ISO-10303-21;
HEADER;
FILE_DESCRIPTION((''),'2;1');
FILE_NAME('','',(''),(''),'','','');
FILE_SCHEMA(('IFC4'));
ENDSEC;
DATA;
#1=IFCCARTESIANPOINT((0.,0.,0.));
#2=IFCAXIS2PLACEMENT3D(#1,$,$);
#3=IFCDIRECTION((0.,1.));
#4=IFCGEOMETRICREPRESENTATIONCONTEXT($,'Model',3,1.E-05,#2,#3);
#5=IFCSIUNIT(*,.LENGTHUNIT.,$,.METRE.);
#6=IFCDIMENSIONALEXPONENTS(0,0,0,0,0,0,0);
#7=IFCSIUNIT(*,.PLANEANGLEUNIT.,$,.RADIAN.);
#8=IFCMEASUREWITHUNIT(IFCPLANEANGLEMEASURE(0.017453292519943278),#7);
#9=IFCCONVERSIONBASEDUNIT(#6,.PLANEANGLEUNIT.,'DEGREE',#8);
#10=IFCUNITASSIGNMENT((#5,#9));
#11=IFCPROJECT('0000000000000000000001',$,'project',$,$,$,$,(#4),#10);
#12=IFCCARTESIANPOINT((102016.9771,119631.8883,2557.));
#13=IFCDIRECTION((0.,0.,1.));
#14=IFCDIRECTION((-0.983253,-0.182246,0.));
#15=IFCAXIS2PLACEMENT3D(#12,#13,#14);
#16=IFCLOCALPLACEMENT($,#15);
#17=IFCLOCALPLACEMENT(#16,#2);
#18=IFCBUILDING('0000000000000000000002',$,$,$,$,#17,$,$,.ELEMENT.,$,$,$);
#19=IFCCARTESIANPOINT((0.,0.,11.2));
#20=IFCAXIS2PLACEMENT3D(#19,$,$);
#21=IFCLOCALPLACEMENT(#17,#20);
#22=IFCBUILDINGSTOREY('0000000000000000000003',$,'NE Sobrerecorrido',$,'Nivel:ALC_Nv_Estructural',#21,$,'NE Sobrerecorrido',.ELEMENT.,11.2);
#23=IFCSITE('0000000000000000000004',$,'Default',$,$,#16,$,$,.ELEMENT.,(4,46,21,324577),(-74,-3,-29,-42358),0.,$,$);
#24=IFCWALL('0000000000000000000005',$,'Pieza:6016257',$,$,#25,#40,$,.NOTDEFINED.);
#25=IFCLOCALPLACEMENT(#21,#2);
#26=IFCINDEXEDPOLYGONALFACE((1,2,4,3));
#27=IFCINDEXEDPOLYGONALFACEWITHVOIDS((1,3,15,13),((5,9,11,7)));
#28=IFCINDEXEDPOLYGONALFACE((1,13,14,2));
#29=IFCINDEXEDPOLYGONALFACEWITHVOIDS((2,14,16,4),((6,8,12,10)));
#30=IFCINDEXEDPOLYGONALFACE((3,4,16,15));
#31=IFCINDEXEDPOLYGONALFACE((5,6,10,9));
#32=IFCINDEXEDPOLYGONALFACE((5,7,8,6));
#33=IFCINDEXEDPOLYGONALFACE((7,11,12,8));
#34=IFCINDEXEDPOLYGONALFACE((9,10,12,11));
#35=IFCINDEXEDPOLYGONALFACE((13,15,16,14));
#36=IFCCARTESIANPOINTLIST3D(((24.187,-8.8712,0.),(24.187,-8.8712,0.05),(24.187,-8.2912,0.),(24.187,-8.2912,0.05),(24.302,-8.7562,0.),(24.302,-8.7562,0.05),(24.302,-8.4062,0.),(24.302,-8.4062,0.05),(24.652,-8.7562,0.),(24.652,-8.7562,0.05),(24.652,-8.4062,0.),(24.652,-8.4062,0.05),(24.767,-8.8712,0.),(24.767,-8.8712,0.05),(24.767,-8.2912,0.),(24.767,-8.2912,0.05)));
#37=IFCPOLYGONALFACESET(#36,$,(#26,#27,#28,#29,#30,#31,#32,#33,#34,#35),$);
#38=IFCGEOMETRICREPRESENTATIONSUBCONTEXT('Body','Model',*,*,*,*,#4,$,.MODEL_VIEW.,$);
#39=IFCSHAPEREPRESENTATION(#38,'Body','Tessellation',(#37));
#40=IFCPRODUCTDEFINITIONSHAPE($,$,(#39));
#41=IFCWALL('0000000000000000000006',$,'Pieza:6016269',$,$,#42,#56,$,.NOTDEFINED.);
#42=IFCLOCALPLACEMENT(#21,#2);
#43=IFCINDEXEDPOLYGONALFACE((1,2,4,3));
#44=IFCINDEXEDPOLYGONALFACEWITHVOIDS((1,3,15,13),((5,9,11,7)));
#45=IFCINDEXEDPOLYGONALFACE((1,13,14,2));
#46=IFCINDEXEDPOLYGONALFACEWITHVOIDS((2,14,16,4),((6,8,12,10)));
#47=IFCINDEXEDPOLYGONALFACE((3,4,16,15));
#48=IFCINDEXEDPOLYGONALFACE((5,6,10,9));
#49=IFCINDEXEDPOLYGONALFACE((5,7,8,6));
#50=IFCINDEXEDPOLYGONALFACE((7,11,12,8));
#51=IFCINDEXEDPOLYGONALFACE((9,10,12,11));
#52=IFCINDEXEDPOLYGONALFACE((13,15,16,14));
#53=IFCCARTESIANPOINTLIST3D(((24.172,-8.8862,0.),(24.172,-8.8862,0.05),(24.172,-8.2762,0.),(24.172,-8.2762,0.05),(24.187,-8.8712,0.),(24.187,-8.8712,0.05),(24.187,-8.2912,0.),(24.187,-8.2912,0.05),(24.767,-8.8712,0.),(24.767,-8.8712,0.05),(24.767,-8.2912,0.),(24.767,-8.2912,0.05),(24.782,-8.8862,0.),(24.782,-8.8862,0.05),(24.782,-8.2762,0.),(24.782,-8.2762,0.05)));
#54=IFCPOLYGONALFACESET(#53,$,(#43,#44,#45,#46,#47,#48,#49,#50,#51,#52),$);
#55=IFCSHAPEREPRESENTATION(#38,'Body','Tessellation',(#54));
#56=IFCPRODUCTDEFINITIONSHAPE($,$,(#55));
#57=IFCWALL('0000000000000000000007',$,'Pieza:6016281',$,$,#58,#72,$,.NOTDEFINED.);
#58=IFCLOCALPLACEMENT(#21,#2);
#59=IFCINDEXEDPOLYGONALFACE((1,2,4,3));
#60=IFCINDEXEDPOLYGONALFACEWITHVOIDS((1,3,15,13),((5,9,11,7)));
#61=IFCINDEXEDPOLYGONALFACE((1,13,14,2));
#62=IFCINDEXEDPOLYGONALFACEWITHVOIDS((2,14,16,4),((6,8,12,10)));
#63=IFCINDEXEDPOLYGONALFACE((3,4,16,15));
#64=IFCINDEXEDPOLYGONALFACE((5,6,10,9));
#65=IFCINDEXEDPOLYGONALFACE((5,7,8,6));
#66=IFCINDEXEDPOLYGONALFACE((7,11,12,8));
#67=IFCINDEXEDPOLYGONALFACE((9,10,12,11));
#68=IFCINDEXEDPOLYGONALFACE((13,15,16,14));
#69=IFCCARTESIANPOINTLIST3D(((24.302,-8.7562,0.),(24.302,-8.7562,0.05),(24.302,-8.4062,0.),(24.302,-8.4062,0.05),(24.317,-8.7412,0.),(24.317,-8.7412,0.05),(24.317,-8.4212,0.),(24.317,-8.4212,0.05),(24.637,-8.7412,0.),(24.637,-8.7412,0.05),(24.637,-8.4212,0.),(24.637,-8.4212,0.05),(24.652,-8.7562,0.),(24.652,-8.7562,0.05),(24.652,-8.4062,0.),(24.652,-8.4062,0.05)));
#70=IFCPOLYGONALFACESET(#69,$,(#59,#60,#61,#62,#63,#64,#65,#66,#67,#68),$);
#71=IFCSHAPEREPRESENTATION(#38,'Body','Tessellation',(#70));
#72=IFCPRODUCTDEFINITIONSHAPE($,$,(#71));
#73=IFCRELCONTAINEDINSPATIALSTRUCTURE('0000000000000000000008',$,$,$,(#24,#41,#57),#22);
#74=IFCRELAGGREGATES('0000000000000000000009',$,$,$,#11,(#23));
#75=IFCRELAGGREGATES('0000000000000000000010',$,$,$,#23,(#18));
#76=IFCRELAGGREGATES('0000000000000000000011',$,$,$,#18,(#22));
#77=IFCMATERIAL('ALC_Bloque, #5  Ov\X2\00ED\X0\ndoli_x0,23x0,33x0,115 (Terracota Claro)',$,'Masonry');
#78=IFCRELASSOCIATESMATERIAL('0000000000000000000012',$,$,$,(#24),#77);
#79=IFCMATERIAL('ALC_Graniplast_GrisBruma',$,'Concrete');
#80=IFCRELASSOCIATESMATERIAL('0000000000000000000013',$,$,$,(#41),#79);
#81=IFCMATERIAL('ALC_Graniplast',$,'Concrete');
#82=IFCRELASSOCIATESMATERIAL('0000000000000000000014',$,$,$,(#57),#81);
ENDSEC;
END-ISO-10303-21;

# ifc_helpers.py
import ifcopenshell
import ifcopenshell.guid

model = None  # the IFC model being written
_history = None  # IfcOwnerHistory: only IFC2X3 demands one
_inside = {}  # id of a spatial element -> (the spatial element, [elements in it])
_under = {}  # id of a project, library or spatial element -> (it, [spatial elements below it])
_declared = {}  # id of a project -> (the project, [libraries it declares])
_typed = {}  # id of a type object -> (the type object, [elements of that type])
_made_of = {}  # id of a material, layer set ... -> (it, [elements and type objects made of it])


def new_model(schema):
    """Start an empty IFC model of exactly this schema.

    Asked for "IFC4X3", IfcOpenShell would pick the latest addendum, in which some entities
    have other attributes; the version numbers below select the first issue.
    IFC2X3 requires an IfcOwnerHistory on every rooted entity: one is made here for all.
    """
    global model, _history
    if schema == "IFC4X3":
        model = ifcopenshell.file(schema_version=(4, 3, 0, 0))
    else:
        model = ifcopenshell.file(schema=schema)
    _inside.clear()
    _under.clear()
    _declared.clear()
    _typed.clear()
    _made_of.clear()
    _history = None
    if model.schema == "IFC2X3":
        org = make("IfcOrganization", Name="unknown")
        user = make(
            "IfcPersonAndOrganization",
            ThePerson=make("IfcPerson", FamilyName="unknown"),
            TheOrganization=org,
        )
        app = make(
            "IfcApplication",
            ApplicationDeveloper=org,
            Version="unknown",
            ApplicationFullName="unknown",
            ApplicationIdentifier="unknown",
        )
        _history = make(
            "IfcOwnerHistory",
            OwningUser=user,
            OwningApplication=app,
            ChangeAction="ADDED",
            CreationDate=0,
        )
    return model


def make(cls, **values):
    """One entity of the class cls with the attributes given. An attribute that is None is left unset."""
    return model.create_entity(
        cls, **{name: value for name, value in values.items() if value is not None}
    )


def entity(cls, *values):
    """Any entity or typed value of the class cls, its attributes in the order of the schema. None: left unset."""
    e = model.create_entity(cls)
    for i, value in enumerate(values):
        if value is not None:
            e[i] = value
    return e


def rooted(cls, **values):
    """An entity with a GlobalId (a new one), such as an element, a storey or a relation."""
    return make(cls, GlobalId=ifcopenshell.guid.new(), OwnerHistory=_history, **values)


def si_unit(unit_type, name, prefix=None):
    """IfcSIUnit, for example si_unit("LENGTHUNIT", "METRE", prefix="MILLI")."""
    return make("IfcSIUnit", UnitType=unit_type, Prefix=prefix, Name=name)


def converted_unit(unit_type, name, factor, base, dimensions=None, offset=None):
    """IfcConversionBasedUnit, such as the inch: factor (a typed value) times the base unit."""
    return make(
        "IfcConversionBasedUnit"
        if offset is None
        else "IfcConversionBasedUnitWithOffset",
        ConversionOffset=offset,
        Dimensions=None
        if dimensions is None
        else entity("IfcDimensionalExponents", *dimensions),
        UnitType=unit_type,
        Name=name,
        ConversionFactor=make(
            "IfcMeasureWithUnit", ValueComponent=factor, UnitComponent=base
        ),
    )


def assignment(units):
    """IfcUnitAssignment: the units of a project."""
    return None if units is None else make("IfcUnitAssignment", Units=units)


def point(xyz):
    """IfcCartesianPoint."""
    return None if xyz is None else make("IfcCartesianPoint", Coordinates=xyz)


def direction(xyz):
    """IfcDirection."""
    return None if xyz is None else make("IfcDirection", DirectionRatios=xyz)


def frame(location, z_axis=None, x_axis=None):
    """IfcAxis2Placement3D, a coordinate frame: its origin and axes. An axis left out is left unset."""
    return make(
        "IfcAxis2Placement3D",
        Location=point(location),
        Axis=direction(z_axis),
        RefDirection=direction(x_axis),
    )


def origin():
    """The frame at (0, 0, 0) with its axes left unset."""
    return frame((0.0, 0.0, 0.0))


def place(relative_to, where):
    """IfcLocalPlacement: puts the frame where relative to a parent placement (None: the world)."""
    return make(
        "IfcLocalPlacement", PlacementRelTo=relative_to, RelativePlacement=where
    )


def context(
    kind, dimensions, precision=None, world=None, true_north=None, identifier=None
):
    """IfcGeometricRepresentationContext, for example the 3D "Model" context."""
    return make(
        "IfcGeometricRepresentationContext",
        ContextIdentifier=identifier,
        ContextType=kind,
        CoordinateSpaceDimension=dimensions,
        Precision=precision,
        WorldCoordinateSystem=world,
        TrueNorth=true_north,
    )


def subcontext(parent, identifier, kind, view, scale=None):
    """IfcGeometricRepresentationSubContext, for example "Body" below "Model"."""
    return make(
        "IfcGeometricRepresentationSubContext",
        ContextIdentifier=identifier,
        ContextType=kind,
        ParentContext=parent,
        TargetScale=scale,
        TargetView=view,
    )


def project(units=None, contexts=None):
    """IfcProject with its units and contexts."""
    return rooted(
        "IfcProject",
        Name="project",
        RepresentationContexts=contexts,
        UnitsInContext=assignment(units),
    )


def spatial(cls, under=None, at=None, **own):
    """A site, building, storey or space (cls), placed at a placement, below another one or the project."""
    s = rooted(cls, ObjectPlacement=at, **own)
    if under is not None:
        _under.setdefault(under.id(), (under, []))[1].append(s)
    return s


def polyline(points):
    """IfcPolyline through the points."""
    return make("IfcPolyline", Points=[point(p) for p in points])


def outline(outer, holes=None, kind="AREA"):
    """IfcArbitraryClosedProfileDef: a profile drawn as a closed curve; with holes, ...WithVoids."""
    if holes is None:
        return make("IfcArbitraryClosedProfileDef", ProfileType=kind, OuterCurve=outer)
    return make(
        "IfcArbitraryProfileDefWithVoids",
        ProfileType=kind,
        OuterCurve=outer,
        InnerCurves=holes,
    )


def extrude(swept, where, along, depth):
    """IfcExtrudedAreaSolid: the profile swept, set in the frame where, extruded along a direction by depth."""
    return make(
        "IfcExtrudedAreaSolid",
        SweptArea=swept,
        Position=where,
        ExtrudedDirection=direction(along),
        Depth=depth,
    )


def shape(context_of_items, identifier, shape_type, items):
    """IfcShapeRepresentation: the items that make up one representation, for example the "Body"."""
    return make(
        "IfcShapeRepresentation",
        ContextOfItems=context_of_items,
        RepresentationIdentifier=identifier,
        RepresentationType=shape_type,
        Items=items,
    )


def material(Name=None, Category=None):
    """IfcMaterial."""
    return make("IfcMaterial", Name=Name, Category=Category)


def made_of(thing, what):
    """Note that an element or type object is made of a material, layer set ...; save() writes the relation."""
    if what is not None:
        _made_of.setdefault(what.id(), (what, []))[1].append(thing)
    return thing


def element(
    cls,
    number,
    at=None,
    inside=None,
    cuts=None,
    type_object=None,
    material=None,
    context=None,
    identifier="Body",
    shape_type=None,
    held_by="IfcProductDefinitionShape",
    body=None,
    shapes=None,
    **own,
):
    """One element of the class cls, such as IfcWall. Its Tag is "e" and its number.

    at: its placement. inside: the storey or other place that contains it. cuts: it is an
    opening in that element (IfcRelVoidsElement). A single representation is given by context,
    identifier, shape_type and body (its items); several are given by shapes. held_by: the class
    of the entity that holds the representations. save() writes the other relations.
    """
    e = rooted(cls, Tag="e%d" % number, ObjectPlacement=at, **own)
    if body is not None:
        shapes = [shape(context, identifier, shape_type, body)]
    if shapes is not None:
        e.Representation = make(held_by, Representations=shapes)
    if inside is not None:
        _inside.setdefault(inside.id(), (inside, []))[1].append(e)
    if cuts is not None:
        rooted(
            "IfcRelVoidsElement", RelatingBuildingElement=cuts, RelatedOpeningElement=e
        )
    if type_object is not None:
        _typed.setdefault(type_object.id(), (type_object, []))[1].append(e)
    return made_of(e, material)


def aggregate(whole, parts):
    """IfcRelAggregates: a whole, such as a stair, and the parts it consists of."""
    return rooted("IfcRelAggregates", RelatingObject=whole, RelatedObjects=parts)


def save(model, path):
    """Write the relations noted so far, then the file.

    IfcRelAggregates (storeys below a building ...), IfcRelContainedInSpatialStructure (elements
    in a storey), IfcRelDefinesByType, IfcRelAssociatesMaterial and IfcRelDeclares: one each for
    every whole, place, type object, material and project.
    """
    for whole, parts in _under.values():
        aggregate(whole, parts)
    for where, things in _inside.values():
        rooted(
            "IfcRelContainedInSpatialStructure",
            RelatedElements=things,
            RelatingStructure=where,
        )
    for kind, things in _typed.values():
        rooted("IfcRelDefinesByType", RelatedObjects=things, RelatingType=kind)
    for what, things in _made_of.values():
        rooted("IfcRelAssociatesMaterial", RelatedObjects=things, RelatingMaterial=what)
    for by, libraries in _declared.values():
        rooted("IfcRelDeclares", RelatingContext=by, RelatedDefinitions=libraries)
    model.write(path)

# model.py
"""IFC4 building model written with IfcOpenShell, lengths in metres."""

from ifc_helpers import new_model, entity, si_unit, converted_unit, direction, frame, origin, place, context, subcontext, project, spatial, polyline, outline, extrude, material, element, save


model = new_model("IFC4")

# Units and contexts
model_context = context("Model", 3, precision=1e-05, world=origin(), true_north=direction((0.0, 1.0)))
body_context = subcontext(model_context, "Body", "Model", "MODEL_VIEW")
ifc_project = project(units=[si_unit("LENGTHUNIT", "METRE"), converted_unit("PLANEANGLEUNIT", "DEGREE", entity("IfcPlaneAngleMeasure", 0.017453292519943278), si_unit("PLANEANGLEUNIT", "RADIAN"), dimensions=[0, 0, 0, 0, 0, 0, 0])], contexts=[model_context])

# Site, building, storey
site_placement = place(None, frame((102016.9771, 119631.8883, 2557.0), z_axis=(0.0, 0.0, 1.0), x_axis=(-0.983253, -0.182246, 0.0)))
site = spatial("IfcSite", under=ifc_project, at=site_placement, Name="Default", CompositionType="ELEMENT", RefLatitude=(4, 46, 21, 324577), RefLongitude=(-74, -3, -29, -42358), RefElevation=0.0)
building_placement = place(site_placement, origin())
building = spatial("IfcBuilding", under=site, at=building_placement, CompositionType="ELEMENT")
storey_placement = place(building_placement, frame((0.0, 0.0, 11.2)))
storey = spatial("IfcBuildingStorey", under=building, at=storey_placement, Name="NE Sobrerecorrido", ObjectType="Nivel:ALC_Nv_Estructural", LongName="NE Sobrerecorrido", CompositionType="ELEMENT", Elevation=11.2)

# Walls
ifc_material_1 = material(Name="ALC_Bloque, #5  Ovíndoli_x0,23x0,33x0,115 (Terracota Claro)", Category="Masonry")
wall_1_placement = place(storey_placement, frame((0.0, 0.0, -1.6)))
element("IfcWall", 1, at=wall_1_placement, inside=storey, material=ifc_material_1, Name="Pieza:6016257", PredefinedType="NOTDEFINED", context=body_context, shape_type="SweptSolid", body=[
    extrude(outline(polyline([(-0.29, -0.29), (0.29, -0.29), (0.29, 0.29), (-0.29, 0.29), (-0.29, -0.29)]), holes=[polyline([(-0.175, 0.175), (0.175, 0.175), (0.175, -0.175), (-0.175, -0.175), (-0.175, 0.175)])]), frame((24.477, -8.5812, 1.6), z_axis=(0.0, 0.0, 1.0), x_axis=(0.0, 1.0, 0.0)), (0.0, 0.0, 1.0), 0.05),
])
ifc_material_2 = material(Name="ALC_Graniplast_GrisBruma", Category="Concrete")
wall_2_placement = place(storey_placement, frame((0.0, 0.0, -1.6)))
element("IfcWall", 2, at=wall_2_placement, inside=storey, material=ifc_material_2, Name="Pieza:6016269", PredefinedType="NOTDEFINED", context=body_context, shape_type="SweptSolid", body=[
    extrude(outline(polyline([(-0.305, -0.305), (0.305, -0.305), (0.305, 0.305), (-0.305, 0.305), (-0.305, -0.305)]), holes=[polyline([(0.29, 0.29), (0.29, -0.29), (-0.29, -0.29), (-0.29, 0.29), (0.29, 0.29)])]), frame((24.477, -8.5812, 1.6), z_axis=(0.0, 0.0, 1.0), x_axis=(-1.0, 0.0, 0.0)), (0.0, 0.0, 1.0), 0.05),
])
ifc_material_3 = material(Name="ALC_Graniplast", Category="Concrete")
wall_3_placement = place(storey_placement, frame((0.0, 0.0, -1.6)))
element("IfcWall", 3, at=wall_3_placement, inside=storey, material=ifc_material_3, Name="Pieza:6016281", PredefinedType="NOTDEFINED", context=body_context, shape_type="SweptSolid", body=[
    extrude(outline(polyline([(-0.175, -0.175), (0.175, -0.175), (0.175, 0.175), (-0.175, 0.175), (-0.175, -0.175)]), holes=[polyline([(-0.16, 0.16), (0.16, 0.16), (0.16, -0.16), (-0.16, -0.16), (-0.16, 0.16)])]), frame((24.477, -8.5812, 1.6), z_axis=(0.0, 0.0, 1.0), x_axis=(0.0, 1.0, 0.0)), (0.0, 0.0, 1.0), 0.05),
])

save(model, "model.ifc")
